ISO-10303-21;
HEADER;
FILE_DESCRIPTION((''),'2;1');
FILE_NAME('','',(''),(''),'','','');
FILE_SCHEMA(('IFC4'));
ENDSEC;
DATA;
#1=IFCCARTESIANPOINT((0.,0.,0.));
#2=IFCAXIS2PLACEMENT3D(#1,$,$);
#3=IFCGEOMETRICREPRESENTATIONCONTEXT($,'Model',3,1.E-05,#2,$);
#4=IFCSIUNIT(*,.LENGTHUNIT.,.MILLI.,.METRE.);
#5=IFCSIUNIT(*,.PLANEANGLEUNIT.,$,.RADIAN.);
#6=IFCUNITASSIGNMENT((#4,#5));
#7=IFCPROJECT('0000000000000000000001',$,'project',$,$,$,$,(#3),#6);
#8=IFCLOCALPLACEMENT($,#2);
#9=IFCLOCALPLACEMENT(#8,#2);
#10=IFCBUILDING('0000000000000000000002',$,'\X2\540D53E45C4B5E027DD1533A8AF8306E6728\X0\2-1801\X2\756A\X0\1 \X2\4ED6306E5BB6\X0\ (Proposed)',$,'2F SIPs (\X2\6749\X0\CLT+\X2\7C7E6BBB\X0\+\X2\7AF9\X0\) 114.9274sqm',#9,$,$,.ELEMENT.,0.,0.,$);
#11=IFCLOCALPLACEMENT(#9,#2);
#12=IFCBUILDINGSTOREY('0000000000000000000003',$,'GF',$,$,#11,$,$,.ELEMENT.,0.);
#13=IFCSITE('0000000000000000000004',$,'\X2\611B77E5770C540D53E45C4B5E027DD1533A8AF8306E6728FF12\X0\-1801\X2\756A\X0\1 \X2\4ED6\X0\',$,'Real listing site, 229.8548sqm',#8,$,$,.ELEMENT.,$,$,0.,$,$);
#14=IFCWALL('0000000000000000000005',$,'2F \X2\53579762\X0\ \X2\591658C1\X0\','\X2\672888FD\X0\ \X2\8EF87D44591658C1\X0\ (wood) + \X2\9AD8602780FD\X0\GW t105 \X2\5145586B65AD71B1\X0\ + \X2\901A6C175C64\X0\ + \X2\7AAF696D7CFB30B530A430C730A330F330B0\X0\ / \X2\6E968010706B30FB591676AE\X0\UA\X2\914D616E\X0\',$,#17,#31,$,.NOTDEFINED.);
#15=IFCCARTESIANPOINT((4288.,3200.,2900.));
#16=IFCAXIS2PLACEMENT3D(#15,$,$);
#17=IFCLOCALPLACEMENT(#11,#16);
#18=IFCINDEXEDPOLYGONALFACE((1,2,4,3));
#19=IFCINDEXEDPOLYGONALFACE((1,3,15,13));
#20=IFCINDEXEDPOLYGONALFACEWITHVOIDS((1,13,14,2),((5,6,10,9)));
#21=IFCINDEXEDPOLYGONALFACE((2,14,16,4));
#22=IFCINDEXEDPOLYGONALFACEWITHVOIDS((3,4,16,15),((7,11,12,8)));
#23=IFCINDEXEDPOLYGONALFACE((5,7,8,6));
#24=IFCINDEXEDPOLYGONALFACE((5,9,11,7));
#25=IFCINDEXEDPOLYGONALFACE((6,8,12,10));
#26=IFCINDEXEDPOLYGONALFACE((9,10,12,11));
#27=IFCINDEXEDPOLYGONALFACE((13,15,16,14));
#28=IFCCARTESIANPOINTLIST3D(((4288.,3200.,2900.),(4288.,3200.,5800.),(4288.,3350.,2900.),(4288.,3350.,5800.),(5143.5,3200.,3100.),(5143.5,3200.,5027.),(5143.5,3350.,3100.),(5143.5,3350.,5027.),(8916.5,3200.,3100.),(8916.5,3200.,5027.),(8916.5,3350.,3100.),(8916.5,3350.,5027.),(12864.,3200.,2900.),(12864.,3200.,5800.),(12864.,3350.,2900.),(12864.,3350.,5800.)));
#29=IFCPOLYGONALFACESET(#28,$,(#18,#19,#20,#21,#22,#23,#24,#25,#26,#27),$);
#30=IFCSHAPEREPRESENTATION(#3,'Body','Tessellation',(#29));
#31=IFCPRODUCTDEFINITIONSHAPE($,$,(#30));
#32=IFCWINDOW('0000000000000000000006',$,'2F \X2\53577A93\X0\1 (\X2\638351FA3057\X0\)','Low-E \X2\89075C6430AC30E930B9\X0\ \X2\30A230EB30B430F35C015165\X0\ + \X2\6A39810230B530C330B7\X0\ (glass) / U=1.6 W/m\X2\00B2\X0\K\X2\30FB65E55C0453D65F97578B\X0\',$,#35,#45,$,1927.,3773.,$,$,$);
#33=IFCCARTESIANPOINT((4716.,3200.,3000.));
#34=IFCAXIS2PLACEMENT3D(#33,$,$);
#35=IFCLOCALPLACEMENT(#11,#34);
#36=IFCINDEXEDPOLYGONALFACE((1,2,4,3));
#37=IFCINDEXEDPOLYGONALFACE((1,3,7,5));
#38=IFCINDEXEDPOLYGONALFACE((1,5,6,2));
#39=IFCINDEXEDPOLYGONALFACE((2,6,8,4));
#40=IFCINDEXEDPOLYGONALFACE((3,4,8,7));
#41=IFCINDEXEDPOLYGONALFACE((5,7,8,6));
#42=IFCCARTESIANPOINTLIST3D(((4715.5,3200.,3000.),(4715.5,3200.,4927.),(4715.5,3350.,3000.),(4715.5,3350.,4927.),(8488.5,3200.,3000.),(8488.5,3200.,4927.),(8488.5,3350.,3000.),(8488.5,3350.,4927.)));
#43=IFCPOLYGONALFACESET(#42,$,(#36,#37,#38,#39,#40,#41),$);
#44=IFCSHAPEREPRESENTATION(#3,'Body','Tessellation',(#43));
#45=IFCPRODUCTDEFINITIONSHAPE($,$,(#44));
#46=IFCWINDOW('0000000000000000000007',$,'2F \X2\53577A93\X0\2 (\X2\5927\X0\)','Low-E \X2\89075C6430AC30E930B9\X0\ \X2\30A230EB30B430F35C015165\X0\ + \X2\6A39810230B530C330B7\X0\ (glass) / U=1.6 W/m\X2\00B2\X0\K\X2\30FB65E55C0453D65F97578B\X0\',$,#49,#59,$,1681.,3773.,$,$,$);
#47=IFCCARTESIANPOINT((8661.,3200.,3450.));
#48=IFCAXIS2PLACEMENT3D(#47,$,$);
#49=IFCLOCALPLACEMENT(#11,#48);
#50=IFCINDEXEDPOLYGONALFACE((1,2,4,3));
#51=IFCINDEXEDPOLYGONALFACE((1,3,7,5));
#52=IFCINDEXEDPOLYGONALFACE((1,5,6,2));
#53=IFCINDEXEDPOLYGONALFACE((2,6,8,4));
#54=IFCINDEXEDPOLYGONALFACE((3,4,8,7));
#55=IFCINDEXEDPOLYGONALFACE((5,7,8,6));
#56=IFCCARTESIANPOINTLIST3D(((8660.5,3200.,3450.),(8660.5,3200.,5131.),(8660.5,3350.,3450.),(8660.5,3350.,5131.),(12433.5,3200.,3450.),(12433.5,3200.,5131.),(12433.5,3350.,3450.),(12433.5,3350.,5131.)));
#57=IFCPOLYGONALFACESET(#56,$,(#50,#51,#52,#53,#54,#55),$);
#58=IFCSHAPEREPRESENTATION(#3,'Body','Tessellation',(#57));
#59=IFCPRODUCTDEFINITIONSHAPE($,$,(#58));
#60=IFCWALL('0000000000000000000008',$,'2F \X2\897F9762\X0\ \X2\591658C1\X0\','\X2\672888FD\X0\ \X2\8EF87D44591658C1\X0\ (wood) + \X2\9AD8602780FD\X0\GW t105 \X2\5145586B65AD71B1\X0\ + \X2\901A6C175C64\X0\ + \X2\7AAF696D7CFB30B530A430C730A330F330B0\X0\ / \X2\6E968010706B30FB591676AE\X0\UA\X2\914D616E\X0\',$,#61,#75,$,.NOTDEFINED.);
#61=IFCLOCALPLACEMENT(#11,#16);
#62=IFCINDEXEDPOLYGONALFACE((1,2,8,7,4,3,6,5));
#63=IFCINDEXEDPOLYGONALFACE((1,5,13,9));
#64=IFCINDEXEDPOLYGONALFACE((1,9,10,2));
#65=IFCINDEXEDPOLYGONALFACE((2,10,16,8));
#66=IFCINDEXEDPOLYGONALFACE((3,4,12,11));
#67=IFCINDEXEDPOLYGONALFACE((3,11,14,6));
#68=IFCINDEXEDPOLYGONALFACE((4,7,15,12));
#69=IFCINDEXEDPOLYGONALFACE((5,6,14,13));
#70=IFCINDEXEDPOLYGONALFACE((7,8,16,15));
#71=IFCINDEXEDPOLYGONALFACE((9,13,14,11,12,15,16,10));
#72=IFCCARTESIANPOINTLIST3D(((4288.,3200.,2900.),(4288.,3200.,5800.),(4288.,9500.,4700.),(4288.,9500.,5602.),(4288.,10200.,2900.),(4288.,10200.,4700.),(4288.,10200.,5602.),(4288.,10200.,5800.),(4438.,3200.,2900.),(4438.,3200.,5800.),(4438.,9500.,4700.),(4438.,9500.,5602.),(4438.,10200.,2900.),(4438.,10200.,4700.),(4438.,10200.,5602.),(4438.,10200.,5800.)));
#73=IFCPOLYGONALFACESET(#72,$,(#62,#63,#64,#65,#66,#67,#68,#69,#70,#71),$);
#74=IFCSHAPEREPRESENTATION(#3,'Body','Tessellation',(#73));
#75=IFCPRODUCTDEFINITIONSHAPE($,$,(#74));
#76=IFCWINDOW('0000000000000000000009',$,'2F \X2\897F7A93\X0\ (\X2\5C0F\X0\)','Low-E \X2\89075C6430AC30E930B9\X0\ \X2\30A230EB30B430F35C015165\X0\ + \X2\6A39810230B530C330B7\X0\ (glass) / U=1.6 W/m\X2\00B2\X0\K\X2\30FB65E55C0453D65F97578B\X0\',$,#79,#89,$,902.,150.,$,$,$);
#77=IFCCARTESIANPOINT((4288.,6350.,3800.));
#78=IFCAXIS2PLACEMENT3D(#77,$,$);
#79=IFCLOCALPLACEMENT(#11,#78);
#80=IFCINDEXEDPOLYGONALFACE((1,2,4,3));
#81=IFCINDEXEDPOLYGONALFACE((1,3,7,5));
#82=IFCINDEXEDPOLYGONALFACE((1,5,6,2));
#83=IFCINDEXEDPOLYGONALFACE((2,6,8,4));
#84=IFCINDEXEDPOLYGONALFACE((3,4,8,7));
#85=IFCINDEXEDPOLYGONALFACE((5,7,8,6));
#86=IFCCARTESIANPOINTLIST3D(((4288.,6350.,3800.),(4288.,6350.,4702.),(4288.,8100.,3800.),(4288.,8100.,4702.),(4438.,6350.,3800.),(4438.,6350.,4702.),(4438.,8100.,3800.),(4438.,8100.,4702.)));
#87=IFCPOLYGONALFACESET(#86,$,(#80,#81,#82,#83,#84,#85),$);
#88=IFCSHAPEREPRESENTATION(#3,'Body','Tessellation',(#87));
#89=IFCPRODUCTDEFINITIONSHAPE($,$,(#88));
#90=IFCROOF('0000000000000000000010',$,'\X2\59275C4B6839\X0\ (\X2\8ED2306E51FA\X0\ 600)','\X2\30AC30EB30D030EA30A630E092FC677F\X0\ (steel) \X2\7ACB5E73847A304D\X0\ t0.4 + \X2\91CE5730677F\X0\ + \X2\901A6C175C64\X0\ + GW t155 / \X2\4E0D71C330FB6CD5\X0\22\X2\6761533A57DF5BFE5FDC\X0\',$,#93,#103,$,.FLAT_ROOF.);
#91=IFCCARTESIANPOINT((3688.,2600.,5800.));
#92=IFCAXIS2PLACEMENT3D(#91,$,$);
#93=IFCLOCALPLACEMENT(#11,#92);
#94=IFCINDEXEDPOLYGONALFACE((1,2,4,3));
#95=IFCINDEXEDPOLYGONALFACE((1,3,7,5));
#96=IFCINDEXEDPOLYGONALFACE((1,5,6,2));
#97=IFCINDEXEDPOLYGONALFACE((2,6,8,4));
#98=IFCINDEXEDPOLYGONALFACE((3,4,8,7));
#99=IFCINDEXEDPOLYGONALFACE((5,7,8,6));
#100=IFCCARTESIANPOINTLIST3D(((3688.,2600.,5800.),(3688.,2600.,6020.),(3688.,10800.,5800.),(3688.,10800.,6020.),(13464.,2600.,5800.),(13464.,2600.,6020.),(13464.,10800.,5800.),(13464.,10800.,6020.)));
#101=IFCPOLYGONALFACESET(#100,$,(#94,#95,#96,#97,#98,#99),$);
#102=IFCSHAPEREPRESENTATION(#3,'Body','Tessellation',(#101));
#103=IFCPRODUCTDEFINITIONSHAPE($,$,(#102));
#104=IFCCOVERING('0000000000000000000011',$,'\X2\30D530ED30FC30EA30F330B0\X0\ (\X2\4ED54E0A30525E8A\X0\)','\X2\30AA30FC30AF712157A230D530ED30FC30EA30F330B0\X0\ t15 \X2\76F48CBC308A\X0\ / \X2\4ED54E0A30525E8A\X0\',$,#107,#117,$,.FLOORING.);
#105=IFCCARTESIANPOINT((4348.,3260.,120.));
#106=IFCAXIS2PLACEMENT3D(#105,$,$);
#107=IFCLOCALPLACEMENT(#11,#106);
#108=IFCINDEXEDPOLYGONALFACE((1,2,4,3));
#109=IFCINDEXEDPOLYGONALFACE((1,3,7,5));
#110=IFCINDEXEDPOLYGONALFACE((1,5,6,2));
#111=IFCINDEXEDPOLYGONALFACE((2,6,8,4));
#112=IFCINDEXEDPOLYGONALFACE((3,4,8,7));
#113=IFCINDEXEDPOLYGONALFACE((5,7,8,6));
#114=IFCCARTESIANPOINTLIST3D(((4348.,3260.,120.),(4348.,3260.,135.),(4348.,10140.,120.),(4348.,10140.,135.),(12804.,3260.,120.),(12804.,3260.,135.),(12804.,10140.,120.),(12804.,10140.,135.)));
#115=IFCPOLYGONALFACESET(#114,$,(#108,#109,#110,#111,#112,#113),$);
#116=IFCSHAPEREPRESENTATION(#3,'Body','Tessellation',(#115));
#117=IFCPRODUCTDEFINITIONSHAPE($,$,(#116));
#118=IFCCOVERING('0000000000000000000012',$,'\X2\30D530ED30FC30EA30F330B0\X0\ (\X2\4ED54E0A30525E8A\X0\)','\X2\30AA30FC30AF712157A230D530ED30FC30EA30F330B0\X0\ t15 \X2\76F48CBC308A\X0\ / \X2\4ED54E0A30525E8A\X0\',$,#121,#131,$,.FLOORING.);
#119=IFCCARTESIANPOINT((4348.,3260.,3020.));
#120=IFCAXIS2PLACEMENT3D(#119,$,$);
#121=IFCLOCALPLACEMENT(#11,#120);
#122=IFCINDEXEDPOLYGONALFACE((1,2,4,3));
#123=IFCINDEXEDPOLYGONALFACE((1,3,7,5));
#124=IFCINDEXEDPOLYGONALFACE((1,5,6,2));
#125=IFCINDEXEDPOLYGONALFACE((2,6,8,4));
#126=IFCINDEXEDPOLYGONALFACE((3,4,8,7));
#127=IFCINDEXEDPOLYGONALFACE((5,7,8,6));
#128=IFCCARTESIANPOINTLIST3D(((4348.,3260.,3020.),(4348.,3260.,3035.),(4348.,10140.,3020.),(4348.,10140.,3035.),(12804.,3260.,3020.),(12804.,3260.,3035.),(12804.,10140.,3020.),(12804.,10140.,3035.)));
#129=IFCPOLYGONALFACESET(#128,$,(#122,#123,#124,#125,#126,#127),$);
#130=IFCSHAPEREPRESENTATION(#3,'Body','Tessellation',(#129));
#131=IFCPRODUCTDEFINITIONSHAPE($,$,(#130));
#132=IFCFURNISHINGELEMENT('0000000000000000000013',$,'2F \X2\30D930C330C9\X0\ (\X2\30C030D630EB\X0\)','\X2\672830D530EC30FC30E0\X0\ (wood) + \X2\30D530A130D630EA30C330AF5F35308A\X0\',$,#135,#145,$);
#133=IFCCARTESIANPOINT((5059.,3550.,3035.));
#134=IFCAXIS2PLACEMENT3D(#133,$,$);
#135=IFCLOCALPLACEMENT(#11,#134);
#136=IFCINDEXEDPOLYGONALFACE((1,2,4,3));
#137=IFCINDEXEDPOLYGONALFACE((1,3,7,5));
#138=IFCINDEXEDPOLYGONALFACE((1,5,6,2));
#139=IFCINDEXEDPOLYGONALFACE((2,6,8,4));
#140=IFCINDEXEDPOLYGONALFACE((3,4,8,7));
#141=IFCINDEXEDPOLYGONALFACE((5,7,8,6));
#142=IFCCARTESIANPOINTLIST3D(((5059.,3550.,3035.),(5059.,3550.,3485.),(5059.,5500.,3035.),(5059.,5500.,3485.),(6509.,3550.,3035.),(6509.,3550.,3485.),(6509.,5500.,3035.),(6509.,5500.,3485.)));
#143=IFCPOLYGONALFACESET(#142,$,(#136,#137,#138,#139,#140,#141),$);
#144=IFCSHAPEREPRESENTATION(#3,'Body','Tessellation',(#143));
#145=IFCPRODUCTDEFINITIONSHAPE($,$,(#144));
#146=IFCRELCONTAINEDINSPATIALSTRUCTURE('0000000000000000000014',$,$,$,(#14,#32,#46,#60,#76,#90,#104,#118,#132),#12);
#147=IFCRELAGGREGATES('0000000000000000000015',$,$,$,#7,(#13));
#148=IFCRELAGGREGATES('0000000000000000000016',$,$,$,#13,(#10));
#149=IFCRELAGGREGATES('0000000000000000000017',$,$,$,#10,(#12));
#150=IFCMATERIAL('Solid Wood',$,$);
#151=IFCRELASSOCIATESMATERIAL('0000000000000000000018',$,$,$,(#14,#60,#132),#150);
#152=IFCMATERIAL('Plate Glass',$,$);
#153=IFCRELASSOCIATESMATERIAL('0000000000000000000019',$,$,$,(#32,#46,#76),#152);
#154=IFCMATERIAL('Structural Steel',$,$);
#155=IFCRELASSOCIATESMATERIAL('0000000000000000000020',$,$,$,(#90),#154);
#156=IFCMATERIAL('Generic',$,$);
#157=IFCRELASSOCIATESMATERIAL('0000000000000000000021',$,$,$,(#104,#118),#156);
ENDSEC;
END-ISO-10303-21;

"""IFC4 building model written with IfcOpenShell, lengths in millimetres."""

from ifc_helpers import new_model, si_unit, frame, frame_2d, origin, place, context, project, spatial, rectangle, extrude, material, element, fill, save


model = new_model("IFC4")

# Units and contexts
model_context = context("Model", 3, precision=1e-05, world=origin())
ifc_project = project(units=[si_unit("LENGTHUNIT", "METRE", prefix="MILLI"), si_unit("PLANEANGLEUNIT", "RADIAN")], contexts=[model_context])

# Site, building, storey
site_placement = place(None, origin())
site = spatial("IfcSite", under=ifc_project, at=site_placement, Name="愛知県名古屋市緑区諸の木２-1801番1 他", ObjectType="Real listing site, 229.8548sqm", CompositionType="ELEMENT", RefElevation=0.0)
building_placement = place(site_placement, origin())
building = spatial("IfcBuilding", under=site, at=building_placement, Name="名古屋市緑区諸の木2-1801番1 他の家 (Proposed)", ObjectType="2F SIPs (杉CLT+籾殻+竹) 114.9274sqm", CompositionType="ELEMENT", ElevationOfRefHeight=0.0, ElevationOfTerrain=0.0)
storey_placement = place(building_placement, origin())
storey = spatial("IfcBuildingStorey", under=building, at=storey_placement, Name="GF", CompositionType="ELEMENT", Elevation=0.0)

# Shared definitions
ifc_material_1 = material(Name="Solid Wood")

# Shared definitions
ifc_material_2 = material(Name="Plate Glass")

# Wall, openings, windows
wall_1_placement = place(storey_placement, frame((4288.0, 3200.0, 2900.0)))
wall_1 = element("IfcWall", 1, at=wall_1_placement, inside=storey, material=ifc_material_1, Name="2F 南面 外壁", Description="木製 軸組外壁 (wood) + 高性能GW t105 充填断熱 + 通気層 + 窯業系サイディング / 準耐火・外皮UA配慮", PredefinedType="NOTDEFINED", context=model_context, shape_type="SweptSolid", body=[
    extrude(rectangle(XDim=8576.0, YDim=150.0, at=frame_2d((4288.0, 75.0))), frame((4288.0, 3200.0, 2900.0)), (0.0, 0.0, 1.0), 2900.0),
])
opening_1_placement = place(storey_placement, frame((4716.0, 3200.0, 3000.0)))
opening_1 = element("IfcOpeningElement", 2, at=opening_1_placement, cuts=wall_1, PredefinedType="NOTDEFINED", context=model_context, shape_type="SweptSolid", body=[
    extrude(rectangle(XDim=3773.0, YDim=150.0, at=frame_2d((1886.0, 75.0))), frame((4716.0, 3200.0, 3000.0)), (0.0, 0.0, 1.0), 1927.0),
])
opening_2_placement = place(storey_placement, frame((8661.0, 3200.0, 3450.0)))
opening_2 = element("IfcOpeningElement", 3, at=opening_2_placement, cuts=wall_1, PredefinedType="NOTDEFINED", context=model_context, shape_type="SweptSolid", body=[
    extrude(rectangle(XDim=3773.0, YDim=150.0, at=frame_2d((1886.0, 75.0))), frame((8661.0, 3200.0, 3450.0)), (0.0, 0.0, 1.0), 1681.0),
])
window_1_placement = place(storey_placement, frame((4716.0, 3200.0, 3000.0)))
window_1 = element("IfcWindow", 4, at=window_1_placement, inside=storey, material=ifc_material_2, Name="2F 南窓1 (掃出し)", Description="Low-E 複層ガラス アルゴン封入 + 樹脂サッシ (glass) / U=1.6 W/m²K・日射取得型", OverallHeight=1927.0, OverallWidth=3773.0, context=model_context, shape_type="SweptSolid", body=[
    extrude(rectangle(XDim=3773.0, YDim=150.0, at=frame_2d((1886.0, 75.0))), frame((4716.0, 3200.0, 3000.0)), (0.0, 0.0, 1.0), 1927.0),
])
fill(opening_1, window_1)
window_2_placement = place(storey_placement, frame((8661.0, 3200.0, 3450.0)))
window_2 = element("IfcWindow", 5, at=window_2_placement, inside=storey, material=ifc_material_2, Name="2F 南窓2 (大)", Description="Low-E 複層ガラス アルゴン封入 + 樹脂サッシ (glass) / U=1.6 W/m²K・日射取得型", OverallHeight=1681.0, OverallWidth=3773.0, context=model_context, shape_type="SweptSolid", body=[
    extrude(rectangle(XDim=3773.0, YDim=150.0, at=frame_2d((1886.0, 75.0))), frame((8661.0, 3200.0, 3450.0)), (0.0, 0.0, 1.0), 1681.0),
])
fill(opening_2, window_2)

# Wall, opening, window
wall_2_placement = place(storey_placement, frame((4288.0, 3200.0, 2900.0)))
wall_2 = element("IfcWall", 6, at=wall_2_placement, inside=storey, material=ifc_material_1, Name="2F 西面 外壁", Description="木製 軸組外壁 (wood) + 高性能GW t105 充填断熱 + 通気層 + 窯業系サイディング / 準耐火・外皮UA配慮", PredefinedType="NOTDEFINED", context=model_context, shape_type="SweptSolid", body=[
    extrude(rectangle(XDim=150.0, YDim=7000.0, at=frame_2d((75.0, 3500.0))), frame((4288.0, 3200.0, 2900.0)), (0.0, 0.0, 1.0), 2900.0),
])
opening_3_placement = place(storey_placement, frame((4288.0, 6350.0, 3800.0)))
opening_3 = element("IfcOpeningElement", 7, at=opening_3_placement, cuts=wall_2, PredefinedType="NOTDEFINED", context=model_context, shape_type="SweptSolid", body=[
    extrude(rectangle(XDim=150.0, YDim=1750.0, at=frame_2d((75.0, 875.0))), frame((4288.0, 6350.0, 3800.0)), (0.0, 0.0, 1.0), 902.0),
])
window_3_placement = place(storey_placement, frame((4288.0, 6350.0, 3800.0)))
window_3 = element("IfcWindow", 8, at=window_3_placement, inside=storey, material=ifc_material_2, Name="2F 西窓 (小)", Description="Low-E 複層ガラス アルゴン封入 + 樹脂サッシ (glass) / U=1.6 W/m²K・日射取得型", OverallHeight=902.0, OverallWidth=150.0, context=model_context, shape_type="SweptSolid", body=[
    extrude(rectangle(XDim=150.0, YDim=1750.0, at=frame_2d((75.0, 875.0))), frame((4288.0, 6350.0, 3800.0)), (0.0, 0.0, 1.0), 902.0),
])
fill(opening_3, window_3)

# Roof
ifc_material_3 = material(Name="Structural Steel")
roof_placement = place(storey_placement, frame((3688.0, 2600.0, 5800.0)))
element("IfcRoof", 9, at=roof_placement, inside=storey, material=ifc_material_3, Name="大屋根 (軒の出 600)", Description="ガルバリウム鋼板 (steel) 立平葺き t0.4 + 野地板 + 通気層 + GW t155 / 不燃・法22条区域対応", PredefinedType="FLAT_ROOF", context=model_context, shape_type="SweptSolid", body=[
    extrude(rectangle(XDim=9776.0, YDim=8200.0, at=frame_2d((4888.0, 4100.0))), frame((3688.0, 2600.0, 5800.0)), (0.0, 0.0, 1.0), 220.0),
])

# Coverings
ifc_material_4 = material(Name="Generic")
covering_1_placement = place(storey_placement, frame((4348.0, 3260.0, 120.0)))
element("IfcCovering", 10, at=covering_1_placement, inside=storey, material=ifc_material_4, Name="フローリング (仕上げ床)", Description="オーク無垢フローリング t15 直貼り / 仕上げ床", PredefinedType="FLOORING", context=model_context, shape_type="SweptSolid", body=[
    extrude(rectangle(XDim=8456.0, YDim=6880.0, at=frame_2d((4228.0, 3440.0))), frame((4348.0, 3260.0, 120.0)), (0.0, 0.0, 1.0), 15.0),
])
covering_2_placement = place(storey_placement, frame((4348.0, 3260.0, 3020.0)))
element("IfcCovering", 11, at=covering_2_placement, inside=storey, material=ifc_material_4, Name="フローリング (仕上げ床)", Description="オーク無垢フローリング t15 直貼り / 仕上げ床", PredefinedType="FLOORING", context=model_context, shape_type="SweptSolid", body=[
    extrude(rectangle(XDim=8456.0, YDim=6880.0, at=frame_2d((4228.0, 3440.0))), frame((4348.0, 3260.0, 3020.0)), (0.0, 0.0, 1.0), 15.0),
])

# Furnishing element
furnishing_placement = place(storey_placement, frame((5059.0, 3550.0, 3035.0)))
element("IfcFurnishingElement", 12, at=furnishing_placement, inside=storey, material=ifc_material_1, Name="2F ベッド (ダブル)", Description="木フレーム (wood) + ファブリック張り", context=model_context, shape_type="SweptSolid", body=[
    extrude(rectangle(XDim=1450.0, YDim=1950.0, at=frame_2d((725.0, 975.0))), frame((5059.0, 3550.0, 3035.0)), (0.0, 0.0, 1.0), 450.0),
])

save(model, "model.ifc")
